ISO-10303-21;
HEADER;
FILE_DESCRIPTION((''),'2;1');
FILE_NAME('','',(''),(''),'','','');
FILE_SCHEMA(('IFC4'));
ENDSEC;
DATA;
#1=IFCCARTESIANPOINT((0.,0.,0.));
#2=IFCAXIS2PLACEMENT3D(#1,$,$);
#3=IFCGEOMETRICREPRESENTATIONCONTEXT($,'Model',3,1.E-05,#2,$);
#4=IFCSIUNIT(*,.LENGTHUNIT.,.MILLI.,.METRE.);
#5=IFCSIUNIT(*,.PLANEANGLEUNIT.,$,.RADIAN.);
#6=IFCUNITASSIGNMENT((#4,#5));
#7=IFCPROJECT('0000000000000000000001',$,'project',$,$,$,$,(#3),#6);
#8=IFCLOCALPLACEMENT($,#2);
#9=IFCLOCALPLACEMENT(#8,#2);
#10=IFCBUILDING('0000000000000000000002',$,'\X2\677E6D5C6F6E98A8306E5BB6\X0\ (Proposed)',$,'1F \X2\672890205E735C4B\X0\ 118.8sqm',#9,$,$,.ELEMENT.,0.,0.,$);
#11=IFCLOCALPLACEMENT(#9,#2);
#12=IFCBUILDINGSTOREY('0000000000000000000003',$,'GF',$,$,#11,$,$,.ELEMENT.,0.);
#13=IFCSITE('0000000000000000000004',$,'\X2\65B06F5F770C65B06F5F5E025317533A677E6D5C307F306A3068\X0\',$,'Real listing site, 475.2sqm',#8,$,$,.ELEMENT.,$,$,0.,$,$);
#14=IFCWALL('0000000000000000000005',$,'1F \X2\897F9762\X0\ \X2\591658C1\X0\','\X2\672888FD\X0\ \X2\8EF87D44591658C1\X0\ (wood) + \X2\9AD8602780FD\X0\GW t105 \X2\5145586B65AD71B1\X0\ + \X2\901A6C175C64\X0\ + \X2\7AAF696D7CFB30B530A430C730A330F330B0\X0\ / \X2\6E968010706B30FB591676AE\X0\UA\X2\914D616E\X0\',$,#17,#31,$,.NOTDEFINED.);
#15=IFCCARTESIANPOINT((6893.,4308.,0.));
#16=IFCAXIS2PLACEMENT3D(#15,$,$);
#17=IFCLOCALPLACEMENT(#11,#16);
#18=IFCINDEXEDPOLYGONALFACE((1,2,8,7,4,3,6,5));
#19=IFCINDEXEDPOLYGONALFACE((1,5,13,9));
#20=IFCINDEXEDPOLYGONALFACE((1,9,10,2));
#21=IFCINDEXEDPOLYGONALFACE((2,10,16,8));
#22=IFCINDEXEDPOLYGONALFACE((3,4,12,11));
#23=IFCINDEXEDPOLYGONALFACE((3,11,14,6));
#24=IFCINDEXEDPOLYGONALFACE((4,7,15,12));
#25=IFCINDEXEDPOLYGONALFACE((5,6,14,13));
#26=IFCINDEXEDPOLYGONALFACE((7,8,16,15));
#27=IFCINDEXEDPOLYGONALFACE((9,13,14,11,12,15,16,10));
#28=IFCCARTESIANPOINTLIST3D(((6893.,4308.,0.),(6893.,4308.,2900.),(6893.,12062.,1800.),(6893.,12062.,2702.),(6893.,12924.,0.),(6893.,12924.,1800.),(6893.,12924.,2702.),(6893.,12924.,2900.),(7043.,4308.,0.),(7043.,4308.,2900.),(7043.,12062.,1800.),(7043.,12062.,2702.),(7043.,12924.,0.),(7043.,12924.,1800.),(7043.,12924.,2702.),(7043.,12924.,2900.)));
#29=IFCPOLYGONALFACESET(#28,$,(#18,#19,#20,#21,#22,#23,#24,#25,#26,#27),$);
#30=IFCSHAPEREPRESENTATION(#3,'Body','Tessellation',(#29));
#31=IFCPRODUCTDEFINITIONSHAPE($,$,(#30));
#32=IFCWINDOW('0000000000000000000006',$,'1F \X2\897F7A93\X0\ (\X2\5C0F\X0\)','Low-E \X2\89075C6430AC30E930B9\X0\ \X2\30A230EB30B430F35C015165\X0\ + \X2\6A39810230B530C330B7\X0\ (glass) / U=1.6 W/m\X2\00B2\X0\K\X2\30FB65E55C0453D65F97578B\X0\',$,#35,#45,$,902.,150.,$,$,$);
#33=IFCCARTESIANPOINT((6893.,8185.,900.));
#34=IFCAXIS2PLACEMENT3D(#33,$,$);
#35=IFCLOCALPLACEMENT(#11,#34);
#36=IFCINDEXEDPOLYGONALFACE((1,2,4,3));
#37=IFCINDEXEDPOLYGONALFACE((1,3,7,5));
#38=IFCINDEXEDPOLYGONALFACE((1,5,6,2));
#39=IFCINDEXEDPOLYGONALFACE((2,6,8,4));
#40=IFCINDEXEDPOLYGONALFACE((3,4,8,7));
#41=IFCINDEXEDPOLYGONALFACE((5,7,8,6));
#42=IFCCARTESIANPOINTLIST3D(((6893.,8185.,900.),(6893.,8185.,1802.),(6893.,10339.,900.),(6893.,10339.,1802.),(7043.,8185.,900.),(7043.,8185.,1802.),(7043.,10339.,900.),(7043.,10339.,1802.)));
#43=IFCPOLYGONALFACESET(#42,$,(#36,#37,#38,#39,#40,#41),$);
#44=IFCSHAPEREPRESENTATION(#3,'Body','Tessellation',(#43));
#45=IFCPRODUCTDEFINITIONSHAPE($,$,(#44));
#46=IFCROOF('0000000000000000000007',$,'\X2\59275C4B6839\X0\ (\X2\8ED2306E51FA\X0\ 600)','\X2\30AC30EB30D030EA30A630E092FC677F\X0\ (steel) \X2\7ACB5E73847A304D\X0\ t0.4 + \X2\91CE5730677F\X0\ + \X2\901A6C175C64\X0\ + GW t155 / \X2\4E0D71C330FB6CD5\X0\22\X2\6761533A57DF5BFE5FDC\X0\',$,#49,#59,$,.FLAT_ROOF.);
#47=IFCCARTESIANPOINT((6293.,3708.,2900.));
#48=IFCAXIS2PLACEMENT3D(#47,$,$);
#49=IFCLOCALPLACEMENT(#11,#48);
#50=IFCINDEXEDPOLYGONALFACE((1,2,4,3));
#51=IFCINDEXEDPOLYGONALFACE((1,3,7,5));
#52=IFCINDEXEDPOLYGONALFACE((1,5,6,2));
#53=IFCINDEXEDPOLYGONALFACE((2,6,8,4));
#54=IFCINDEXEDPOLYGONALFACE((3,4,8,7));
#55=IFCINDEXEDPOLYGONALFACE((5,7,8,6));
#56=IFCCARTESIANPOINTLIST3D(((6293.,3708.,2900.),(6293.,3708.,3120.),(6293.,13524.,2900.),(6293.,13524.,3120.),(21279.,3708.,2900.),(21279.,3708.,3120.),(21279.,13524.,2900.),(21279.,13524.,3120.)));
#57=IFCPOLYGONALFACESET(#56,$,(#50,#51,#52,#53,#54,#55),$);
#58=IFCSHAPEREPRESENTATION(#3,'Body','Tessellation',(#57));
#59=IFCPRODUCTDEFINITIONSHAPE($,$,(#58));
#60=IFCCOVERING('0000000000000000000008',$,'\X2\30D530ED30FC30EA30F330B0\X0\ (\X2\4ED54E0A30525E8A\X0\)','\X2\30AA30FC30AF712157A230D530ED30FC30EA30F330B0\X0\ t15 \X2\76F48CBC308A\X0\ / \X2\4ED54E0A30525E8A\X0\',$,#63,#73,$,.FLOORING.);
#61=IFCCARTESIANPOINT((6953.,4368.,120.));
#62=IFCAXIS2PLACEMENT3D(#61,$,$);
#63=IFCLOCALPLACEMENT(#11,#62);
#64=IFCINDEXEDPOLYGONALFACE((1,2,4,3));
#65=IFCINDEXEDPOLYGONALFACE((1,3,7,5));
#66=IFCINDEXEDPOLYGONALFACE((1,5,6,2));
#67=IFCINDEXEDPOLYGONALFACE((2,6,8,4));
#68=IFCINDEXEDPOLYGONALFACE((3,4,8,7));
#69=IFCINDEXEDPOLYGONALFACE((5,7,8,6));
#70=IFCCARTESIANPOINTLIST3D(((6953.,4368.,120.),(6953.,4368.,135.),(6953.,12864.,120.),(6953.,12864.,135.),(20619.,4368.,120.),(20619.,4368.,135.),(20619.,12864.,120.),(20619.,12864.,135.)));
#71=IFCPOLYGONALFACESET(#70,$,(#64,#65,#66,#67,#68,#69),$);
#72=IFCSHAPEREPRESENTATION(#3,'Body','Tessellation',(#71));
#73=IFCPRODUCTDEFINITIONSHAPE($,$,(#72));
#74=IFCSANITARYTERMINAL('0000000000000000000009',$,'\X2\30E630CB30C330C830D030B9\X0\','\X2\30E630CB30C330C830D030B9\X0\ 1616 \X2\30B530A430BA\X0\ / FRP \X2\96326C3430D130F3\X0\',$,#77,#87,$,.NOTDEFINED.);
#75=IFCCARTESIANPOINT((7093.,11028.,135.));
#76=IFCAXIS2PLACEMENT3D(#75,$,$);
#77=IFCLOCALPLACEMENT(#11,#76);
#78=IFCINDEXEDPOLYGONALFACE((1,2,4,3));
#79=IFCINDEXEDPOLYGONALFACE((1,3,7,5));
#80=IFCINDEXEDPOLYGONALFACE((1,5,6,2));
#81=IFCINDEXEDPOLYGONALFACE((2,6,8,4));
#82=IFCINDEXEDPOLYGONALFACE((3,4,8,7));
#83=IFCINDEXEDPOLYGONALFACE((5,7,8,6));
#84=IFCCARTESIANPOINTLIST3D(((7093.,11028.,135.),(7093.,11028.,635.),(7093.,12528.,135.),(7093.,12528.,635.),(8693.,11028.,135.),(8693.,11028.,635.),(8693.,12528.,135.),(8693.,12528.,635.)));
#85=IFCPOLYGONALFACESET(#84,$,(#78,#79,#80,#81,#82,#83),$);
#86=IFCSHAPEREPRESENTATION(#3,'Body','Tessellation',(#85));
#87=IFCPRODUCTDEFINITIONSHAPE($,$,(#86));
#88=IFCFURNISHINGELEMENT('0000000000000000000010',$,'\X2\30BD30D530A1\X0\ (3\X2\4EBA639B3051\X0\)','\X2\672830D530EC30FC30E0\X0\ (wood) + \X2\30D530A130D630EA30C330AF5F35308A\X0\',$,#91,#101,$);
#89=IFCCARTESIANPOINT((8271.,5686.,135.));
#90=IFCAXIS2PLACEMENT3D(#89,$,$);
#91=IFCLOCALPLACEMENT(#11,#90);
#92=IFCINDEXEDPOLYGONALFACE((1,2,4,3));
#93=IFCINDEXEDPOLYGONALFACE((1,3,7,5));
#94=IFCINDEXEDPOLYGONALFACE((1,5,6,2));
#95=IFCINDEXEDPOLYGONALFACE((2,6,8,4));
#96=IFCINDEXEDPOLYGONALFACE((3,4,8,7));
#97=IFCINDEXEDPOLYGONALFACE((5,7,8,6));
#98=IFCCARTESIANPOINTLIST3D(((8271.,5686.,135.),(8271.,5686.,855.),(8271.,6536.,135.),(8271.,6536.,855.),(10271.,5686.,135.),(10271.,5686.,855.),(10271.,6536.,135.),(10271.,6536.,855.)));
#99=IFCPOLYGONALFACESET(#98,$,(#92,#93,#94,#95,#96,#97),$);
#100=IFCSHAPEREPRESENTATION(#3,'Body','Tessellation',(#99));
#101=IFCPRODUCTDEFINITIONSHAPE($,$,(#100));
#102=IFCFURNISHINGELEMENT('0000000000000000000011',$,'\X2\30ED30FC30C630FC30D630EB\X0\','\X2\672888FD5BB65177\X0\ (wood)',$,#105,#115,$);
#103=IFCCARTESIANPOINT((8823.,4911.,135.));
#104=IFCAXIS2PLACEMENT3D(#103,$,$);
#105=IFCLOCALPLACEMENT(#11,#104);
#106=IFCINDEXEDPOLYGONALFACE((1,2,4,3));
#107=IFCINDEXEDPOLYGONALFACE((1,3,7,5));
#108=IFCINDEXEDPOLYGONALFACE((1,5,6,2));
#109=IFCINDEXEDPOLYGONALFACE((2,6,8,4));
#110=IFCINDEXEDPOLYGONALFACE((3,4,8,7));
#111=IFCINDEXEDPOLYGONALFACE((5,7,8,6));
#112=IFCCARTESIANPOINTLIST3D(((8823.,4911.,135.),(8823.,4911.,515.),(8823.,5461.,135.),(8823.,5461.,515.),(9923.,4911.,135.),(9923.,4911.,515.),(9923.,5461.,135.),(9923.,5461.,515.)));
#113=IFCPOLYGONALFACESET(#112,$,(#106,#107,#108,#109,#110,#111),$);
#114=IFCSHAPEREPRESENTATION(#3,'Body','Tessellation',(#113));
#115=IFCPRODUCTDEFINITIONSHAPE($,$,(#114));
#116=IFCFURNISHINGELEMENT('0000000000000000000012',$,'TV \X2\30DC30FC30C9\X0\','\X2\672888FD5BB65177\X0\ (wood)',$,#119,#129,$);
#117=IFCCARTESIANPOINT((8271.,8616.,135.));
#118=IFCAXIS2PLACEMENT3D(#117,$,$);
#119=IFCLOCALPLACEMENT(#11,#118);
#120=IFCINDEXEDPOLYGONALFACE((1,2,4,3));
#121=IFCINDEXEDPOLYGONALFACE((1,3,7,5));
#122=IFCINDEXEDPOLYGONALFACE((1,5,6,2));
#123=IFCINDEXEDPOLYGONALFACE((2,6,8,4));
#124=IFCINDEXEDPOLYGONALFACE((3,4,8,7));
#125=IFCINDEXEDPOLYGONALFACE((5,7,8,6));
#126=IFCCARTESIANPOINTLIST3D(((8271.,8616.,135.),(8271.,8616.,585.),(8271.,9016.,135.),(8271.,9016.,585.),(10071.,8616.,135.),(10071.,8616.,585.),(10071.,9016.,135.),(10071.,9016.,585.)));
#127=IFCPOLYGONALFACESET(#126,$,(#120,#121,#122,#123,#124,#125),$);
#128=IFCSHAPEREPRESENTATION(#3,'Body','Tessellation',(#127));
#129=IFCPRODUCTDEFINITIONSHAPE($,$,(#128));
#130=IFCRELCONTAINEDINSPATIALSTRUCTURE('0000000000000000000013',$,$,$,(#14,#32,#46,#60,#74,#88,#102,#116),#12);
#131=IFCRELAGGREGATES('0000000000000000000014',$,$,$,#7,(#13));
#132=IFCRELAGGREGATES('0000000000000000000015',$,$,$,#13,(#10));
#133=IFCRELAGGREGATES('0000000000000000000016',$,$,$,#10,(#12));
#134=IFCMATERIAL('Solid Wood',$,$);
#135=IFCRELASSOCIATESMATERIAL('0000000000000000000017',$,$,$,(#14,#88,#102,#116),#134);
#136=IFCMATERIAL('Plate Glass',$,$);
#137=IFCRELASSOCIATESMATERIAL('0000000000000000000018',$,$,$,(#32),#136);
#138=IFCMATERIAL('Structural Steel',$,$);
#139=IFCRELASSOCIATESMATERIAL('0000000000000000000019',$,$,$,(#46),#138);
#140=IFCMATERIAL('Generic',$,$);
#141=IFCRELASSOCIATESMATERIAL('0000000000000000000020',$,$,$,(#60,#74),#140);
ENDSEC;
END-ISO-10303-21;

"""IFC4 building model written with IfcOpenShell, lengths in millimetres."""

from ifc_helpers import new_model, si_unit, frame, frame_2d, origin, place, context, project, spatial, rectangle, extrude, material, element, fill, save


model = new_model("IFC4")

# Units and contexts
model_context = context("Model", 3, precision=1e-05, world=origin())
ifc_project = project(units=[si_unit("LENGTHUNIT", "METRE", prefix="MILLI"), si_unit("PLANEANGLEUNIT", "RADIAN")], contexts=[model_context])

# Site, building, storey
site_placement = place(None, origin())
site = spatial("IfcSite", under=ifc_project, at=site_placement, Name="新潟県新潟市北区松浜みなと", ObjectType="Real listing site, 475.2sqm", CompositionType="ELEMENT", RefElevation=0.0)
building_placement = place(site_placement, origin())
building = spatial("IfcBuilding", under=site, at=building_placement, Name="松浜潮風の家 (Proposed)", ObjectType="1F 木造平屋 118.8sqm", CompositionType="ELEMENT", ElevationOfRefHeight=0.0, ElevationOfTerrain=0.0)
storey_placement = place(building_placement, origin())
storey = spatial("IfcBuildingStorey", under=building, at=storey_placement, Name="GF", CompositionType="ELEMENT", Elevation=0.0)

# Shared definitions
ifc_material_1 = material(Name="Solid Wood")

# Shared definitions
ifc_material_2 = material(Name="Plate Glass")

# Wall, opening, window
wall_1_placement = place(storey_placement, frame((6893.0, 4308.0, 0.0)))
wall_1 = element("IfcWall", 1, at=wall_1_placement, inside=storey, material=ifc_material_1, Name="1F 西面 外壁", Description="木製 軸組外壁 (wood) + 高性能GW t105 充填断熱 + 通気層 + 窯業系サイディング / 準耐火・外皮UA配慮", PredefinedType="NOTDEFINED", context=model_context, shape_type="SweptSolid", body=[
    extrude(rectangle(XDim=150.0, YDim=8616.0, at=frame_2d((75.0, 4308.0))), frame((6893.0, 4308.0, 0.0)), (0.0, 0.0, 1.0), 2900.0),
])
opening_1_placement = place(storey_placement, frame((6893.0, 8185.0, 900.0)))
opening_1 = element("IfcOpeningElement", 2, at=opening_1_placement, cuts=wall_1, PredefinedType="NOTDEFINED", context=model_context, shape_type="SweptSolid", body=[
    extrude(rectangle(XDim=150.0, YDim=2154.0, at=frame_2d((75.0, 1077.0))), frame((6893.0, 8185.0, 900.0)), (0.0, 0.0, 1.0), 902.0),
])
window_1_placement = place(storey_placement, frame((6893.0, 8185.0, 900.0)))
window_1 = element("IfcWindow", 3, at=window_1_placement, inside=storey, material=ifc_material_2, Name="1F 西窓 (小)", Description="Low-E 複層ガラス アルゴン封入 + 樹脂サッシ (glass) / U=1.6 W/m²K・日射取得型", OverallHeight=902.0, OverallWidth=150.0, context=model_context, shape_type="SweptSolid", body=[
    extrude(rectangle(XDim=150.0, YDim=2154.0, at=frame_2d((75.0, 1077.0))), frame((6893.0, 8185.0, 900.0)), (0.0, 0.0, 1.0), 902.0),
])
fill(opening_1, window_1)

# Roof
ifc_material_3 = material(Name="Structural Steel")
roof_placement = place(storey_placement, frame((6293.0, 3708.0, 2900.0)))
element("IfcRoof", 4, at=roof_placement, inside=storey, material=ifc_material_3, Name="大屋根 (軒の出 600)", Description="ガルバリウム鋼板 (steel) 立平葺き t0.4 + 野地板 + 通気層 + GW t155 / 不燃・法22条区域対応", PredefinedType="FLAT_ROOF", context=model_context, shape_type="SweptSolid", body=[
    extrude(rectangle(XDim=14986.0, YDim=9816.0, at=frame_2d((7493.0, 4908.0))), frame((6293.0, 3708.0, 2900.0)), (0.0, 0.0, 1.0), 220.0),
])

# Covering
ifc_material_4 = material(Name="Generic")
covering_placement = place(storey_placement, frame((6953.0, 4368.0, 120.0)))
element("IfcCovering", 5, at=covering_placement, inside=storey, material=ifc_material_4, Name="フローリング (仕上げ床)", Description="オーク無垢フローリング t15 直貼り / 仕上げ床", PredefinedType="FLOORING", context=model_context, shape_type="SweptSolid", body=[
    extrude(rectangle(XDim=13666.0, YDim=8496.0, at=frame_2d((6833.0, 4248.0))), frame((6953.0, 4368.0, 120.0)), (0.0, 0.0, 1.0), 15.0),
])

# Sanitary terminal
sanitary_terminal_placement = place(storey_placement, frame((7093.0, 11028.0, 135.0)))
element("IfcSanitaryTerminal", 6, at=sanitary_terminal_placement, inside=storey, material=ifc_material_4, Name="ユニットバス", Description="ユニットバス 1616 サイズ / FRP 防水パン", PredefinedType="NOTDEFINED", context=model_context, shape_type="SweptSolid", body=[
    extrude(rectangle(XDim=1600.0, YDim=1500.0, at=frame_2d((800.0, 750.0))), frame((7093.0, 11028.0, 135.0)), (0.0, 0.0, 1.0), 500.0),
])

# Furnishing elements
furnishing_1_placement = place(storey_placement, frame((8271.0, 5686.0, 135.0)))
element("IfcFurnishingElement", 7, at=furnishing_1_placement, inside=storey, material=ifc_material_1, Name="ソファ (3人掛け)", Description="木フレーム (wood) + ファブリック張り", context=model_context, shape_type="SweptSolid", body=[
    extrude(rectangle(XDim=2000.0, YDim=850.0, at=frame_2d((1000.0, 425.0))), frame((8271.0, 5686.0, 135.0)), (0.0, 0.0, 1.0), 720.0),
])
furnishing_2_placement = place(storey_placement, frame((8823.0, 4911.0, 135.0)))
element("IfcFurnishingElement", 8, at=furnishing_2_placement, inside=storey, material=ifc_material_1, Name="ローテーブル", Description="木製家具 (wood)", context=model_context, shape_type="SweptSolid", body=[
    extrude(rectangle(XDim=1100.0, YDim=550.0, at=frame_2d((550.0, 275.0))), frame((8823.0, 4911.0, 135.0)), (0.0, 0.0, 1.0), 380.0),
])
furnishing_3_placement = place(storey_placement, frame((8271.0, 8616.0, 135.0)))
element("IfcFurnishingElement", 9, at=furnishing_3_placement, inside=storey, material=ifc_material_1, Name="TV ボード", Description="木製家具 (wood)", context=model_context, shape_type="SweptSolid", body=[
    extrude(rectangle(XDim=1800.0, YDim=400.0, at=frame_2d((900.0, 200.0))), frame((8271.0, 8616.0, 135.0)), (0.0, 0.0, 1.0), 450.0),
])

save(model, "model.ifc")
